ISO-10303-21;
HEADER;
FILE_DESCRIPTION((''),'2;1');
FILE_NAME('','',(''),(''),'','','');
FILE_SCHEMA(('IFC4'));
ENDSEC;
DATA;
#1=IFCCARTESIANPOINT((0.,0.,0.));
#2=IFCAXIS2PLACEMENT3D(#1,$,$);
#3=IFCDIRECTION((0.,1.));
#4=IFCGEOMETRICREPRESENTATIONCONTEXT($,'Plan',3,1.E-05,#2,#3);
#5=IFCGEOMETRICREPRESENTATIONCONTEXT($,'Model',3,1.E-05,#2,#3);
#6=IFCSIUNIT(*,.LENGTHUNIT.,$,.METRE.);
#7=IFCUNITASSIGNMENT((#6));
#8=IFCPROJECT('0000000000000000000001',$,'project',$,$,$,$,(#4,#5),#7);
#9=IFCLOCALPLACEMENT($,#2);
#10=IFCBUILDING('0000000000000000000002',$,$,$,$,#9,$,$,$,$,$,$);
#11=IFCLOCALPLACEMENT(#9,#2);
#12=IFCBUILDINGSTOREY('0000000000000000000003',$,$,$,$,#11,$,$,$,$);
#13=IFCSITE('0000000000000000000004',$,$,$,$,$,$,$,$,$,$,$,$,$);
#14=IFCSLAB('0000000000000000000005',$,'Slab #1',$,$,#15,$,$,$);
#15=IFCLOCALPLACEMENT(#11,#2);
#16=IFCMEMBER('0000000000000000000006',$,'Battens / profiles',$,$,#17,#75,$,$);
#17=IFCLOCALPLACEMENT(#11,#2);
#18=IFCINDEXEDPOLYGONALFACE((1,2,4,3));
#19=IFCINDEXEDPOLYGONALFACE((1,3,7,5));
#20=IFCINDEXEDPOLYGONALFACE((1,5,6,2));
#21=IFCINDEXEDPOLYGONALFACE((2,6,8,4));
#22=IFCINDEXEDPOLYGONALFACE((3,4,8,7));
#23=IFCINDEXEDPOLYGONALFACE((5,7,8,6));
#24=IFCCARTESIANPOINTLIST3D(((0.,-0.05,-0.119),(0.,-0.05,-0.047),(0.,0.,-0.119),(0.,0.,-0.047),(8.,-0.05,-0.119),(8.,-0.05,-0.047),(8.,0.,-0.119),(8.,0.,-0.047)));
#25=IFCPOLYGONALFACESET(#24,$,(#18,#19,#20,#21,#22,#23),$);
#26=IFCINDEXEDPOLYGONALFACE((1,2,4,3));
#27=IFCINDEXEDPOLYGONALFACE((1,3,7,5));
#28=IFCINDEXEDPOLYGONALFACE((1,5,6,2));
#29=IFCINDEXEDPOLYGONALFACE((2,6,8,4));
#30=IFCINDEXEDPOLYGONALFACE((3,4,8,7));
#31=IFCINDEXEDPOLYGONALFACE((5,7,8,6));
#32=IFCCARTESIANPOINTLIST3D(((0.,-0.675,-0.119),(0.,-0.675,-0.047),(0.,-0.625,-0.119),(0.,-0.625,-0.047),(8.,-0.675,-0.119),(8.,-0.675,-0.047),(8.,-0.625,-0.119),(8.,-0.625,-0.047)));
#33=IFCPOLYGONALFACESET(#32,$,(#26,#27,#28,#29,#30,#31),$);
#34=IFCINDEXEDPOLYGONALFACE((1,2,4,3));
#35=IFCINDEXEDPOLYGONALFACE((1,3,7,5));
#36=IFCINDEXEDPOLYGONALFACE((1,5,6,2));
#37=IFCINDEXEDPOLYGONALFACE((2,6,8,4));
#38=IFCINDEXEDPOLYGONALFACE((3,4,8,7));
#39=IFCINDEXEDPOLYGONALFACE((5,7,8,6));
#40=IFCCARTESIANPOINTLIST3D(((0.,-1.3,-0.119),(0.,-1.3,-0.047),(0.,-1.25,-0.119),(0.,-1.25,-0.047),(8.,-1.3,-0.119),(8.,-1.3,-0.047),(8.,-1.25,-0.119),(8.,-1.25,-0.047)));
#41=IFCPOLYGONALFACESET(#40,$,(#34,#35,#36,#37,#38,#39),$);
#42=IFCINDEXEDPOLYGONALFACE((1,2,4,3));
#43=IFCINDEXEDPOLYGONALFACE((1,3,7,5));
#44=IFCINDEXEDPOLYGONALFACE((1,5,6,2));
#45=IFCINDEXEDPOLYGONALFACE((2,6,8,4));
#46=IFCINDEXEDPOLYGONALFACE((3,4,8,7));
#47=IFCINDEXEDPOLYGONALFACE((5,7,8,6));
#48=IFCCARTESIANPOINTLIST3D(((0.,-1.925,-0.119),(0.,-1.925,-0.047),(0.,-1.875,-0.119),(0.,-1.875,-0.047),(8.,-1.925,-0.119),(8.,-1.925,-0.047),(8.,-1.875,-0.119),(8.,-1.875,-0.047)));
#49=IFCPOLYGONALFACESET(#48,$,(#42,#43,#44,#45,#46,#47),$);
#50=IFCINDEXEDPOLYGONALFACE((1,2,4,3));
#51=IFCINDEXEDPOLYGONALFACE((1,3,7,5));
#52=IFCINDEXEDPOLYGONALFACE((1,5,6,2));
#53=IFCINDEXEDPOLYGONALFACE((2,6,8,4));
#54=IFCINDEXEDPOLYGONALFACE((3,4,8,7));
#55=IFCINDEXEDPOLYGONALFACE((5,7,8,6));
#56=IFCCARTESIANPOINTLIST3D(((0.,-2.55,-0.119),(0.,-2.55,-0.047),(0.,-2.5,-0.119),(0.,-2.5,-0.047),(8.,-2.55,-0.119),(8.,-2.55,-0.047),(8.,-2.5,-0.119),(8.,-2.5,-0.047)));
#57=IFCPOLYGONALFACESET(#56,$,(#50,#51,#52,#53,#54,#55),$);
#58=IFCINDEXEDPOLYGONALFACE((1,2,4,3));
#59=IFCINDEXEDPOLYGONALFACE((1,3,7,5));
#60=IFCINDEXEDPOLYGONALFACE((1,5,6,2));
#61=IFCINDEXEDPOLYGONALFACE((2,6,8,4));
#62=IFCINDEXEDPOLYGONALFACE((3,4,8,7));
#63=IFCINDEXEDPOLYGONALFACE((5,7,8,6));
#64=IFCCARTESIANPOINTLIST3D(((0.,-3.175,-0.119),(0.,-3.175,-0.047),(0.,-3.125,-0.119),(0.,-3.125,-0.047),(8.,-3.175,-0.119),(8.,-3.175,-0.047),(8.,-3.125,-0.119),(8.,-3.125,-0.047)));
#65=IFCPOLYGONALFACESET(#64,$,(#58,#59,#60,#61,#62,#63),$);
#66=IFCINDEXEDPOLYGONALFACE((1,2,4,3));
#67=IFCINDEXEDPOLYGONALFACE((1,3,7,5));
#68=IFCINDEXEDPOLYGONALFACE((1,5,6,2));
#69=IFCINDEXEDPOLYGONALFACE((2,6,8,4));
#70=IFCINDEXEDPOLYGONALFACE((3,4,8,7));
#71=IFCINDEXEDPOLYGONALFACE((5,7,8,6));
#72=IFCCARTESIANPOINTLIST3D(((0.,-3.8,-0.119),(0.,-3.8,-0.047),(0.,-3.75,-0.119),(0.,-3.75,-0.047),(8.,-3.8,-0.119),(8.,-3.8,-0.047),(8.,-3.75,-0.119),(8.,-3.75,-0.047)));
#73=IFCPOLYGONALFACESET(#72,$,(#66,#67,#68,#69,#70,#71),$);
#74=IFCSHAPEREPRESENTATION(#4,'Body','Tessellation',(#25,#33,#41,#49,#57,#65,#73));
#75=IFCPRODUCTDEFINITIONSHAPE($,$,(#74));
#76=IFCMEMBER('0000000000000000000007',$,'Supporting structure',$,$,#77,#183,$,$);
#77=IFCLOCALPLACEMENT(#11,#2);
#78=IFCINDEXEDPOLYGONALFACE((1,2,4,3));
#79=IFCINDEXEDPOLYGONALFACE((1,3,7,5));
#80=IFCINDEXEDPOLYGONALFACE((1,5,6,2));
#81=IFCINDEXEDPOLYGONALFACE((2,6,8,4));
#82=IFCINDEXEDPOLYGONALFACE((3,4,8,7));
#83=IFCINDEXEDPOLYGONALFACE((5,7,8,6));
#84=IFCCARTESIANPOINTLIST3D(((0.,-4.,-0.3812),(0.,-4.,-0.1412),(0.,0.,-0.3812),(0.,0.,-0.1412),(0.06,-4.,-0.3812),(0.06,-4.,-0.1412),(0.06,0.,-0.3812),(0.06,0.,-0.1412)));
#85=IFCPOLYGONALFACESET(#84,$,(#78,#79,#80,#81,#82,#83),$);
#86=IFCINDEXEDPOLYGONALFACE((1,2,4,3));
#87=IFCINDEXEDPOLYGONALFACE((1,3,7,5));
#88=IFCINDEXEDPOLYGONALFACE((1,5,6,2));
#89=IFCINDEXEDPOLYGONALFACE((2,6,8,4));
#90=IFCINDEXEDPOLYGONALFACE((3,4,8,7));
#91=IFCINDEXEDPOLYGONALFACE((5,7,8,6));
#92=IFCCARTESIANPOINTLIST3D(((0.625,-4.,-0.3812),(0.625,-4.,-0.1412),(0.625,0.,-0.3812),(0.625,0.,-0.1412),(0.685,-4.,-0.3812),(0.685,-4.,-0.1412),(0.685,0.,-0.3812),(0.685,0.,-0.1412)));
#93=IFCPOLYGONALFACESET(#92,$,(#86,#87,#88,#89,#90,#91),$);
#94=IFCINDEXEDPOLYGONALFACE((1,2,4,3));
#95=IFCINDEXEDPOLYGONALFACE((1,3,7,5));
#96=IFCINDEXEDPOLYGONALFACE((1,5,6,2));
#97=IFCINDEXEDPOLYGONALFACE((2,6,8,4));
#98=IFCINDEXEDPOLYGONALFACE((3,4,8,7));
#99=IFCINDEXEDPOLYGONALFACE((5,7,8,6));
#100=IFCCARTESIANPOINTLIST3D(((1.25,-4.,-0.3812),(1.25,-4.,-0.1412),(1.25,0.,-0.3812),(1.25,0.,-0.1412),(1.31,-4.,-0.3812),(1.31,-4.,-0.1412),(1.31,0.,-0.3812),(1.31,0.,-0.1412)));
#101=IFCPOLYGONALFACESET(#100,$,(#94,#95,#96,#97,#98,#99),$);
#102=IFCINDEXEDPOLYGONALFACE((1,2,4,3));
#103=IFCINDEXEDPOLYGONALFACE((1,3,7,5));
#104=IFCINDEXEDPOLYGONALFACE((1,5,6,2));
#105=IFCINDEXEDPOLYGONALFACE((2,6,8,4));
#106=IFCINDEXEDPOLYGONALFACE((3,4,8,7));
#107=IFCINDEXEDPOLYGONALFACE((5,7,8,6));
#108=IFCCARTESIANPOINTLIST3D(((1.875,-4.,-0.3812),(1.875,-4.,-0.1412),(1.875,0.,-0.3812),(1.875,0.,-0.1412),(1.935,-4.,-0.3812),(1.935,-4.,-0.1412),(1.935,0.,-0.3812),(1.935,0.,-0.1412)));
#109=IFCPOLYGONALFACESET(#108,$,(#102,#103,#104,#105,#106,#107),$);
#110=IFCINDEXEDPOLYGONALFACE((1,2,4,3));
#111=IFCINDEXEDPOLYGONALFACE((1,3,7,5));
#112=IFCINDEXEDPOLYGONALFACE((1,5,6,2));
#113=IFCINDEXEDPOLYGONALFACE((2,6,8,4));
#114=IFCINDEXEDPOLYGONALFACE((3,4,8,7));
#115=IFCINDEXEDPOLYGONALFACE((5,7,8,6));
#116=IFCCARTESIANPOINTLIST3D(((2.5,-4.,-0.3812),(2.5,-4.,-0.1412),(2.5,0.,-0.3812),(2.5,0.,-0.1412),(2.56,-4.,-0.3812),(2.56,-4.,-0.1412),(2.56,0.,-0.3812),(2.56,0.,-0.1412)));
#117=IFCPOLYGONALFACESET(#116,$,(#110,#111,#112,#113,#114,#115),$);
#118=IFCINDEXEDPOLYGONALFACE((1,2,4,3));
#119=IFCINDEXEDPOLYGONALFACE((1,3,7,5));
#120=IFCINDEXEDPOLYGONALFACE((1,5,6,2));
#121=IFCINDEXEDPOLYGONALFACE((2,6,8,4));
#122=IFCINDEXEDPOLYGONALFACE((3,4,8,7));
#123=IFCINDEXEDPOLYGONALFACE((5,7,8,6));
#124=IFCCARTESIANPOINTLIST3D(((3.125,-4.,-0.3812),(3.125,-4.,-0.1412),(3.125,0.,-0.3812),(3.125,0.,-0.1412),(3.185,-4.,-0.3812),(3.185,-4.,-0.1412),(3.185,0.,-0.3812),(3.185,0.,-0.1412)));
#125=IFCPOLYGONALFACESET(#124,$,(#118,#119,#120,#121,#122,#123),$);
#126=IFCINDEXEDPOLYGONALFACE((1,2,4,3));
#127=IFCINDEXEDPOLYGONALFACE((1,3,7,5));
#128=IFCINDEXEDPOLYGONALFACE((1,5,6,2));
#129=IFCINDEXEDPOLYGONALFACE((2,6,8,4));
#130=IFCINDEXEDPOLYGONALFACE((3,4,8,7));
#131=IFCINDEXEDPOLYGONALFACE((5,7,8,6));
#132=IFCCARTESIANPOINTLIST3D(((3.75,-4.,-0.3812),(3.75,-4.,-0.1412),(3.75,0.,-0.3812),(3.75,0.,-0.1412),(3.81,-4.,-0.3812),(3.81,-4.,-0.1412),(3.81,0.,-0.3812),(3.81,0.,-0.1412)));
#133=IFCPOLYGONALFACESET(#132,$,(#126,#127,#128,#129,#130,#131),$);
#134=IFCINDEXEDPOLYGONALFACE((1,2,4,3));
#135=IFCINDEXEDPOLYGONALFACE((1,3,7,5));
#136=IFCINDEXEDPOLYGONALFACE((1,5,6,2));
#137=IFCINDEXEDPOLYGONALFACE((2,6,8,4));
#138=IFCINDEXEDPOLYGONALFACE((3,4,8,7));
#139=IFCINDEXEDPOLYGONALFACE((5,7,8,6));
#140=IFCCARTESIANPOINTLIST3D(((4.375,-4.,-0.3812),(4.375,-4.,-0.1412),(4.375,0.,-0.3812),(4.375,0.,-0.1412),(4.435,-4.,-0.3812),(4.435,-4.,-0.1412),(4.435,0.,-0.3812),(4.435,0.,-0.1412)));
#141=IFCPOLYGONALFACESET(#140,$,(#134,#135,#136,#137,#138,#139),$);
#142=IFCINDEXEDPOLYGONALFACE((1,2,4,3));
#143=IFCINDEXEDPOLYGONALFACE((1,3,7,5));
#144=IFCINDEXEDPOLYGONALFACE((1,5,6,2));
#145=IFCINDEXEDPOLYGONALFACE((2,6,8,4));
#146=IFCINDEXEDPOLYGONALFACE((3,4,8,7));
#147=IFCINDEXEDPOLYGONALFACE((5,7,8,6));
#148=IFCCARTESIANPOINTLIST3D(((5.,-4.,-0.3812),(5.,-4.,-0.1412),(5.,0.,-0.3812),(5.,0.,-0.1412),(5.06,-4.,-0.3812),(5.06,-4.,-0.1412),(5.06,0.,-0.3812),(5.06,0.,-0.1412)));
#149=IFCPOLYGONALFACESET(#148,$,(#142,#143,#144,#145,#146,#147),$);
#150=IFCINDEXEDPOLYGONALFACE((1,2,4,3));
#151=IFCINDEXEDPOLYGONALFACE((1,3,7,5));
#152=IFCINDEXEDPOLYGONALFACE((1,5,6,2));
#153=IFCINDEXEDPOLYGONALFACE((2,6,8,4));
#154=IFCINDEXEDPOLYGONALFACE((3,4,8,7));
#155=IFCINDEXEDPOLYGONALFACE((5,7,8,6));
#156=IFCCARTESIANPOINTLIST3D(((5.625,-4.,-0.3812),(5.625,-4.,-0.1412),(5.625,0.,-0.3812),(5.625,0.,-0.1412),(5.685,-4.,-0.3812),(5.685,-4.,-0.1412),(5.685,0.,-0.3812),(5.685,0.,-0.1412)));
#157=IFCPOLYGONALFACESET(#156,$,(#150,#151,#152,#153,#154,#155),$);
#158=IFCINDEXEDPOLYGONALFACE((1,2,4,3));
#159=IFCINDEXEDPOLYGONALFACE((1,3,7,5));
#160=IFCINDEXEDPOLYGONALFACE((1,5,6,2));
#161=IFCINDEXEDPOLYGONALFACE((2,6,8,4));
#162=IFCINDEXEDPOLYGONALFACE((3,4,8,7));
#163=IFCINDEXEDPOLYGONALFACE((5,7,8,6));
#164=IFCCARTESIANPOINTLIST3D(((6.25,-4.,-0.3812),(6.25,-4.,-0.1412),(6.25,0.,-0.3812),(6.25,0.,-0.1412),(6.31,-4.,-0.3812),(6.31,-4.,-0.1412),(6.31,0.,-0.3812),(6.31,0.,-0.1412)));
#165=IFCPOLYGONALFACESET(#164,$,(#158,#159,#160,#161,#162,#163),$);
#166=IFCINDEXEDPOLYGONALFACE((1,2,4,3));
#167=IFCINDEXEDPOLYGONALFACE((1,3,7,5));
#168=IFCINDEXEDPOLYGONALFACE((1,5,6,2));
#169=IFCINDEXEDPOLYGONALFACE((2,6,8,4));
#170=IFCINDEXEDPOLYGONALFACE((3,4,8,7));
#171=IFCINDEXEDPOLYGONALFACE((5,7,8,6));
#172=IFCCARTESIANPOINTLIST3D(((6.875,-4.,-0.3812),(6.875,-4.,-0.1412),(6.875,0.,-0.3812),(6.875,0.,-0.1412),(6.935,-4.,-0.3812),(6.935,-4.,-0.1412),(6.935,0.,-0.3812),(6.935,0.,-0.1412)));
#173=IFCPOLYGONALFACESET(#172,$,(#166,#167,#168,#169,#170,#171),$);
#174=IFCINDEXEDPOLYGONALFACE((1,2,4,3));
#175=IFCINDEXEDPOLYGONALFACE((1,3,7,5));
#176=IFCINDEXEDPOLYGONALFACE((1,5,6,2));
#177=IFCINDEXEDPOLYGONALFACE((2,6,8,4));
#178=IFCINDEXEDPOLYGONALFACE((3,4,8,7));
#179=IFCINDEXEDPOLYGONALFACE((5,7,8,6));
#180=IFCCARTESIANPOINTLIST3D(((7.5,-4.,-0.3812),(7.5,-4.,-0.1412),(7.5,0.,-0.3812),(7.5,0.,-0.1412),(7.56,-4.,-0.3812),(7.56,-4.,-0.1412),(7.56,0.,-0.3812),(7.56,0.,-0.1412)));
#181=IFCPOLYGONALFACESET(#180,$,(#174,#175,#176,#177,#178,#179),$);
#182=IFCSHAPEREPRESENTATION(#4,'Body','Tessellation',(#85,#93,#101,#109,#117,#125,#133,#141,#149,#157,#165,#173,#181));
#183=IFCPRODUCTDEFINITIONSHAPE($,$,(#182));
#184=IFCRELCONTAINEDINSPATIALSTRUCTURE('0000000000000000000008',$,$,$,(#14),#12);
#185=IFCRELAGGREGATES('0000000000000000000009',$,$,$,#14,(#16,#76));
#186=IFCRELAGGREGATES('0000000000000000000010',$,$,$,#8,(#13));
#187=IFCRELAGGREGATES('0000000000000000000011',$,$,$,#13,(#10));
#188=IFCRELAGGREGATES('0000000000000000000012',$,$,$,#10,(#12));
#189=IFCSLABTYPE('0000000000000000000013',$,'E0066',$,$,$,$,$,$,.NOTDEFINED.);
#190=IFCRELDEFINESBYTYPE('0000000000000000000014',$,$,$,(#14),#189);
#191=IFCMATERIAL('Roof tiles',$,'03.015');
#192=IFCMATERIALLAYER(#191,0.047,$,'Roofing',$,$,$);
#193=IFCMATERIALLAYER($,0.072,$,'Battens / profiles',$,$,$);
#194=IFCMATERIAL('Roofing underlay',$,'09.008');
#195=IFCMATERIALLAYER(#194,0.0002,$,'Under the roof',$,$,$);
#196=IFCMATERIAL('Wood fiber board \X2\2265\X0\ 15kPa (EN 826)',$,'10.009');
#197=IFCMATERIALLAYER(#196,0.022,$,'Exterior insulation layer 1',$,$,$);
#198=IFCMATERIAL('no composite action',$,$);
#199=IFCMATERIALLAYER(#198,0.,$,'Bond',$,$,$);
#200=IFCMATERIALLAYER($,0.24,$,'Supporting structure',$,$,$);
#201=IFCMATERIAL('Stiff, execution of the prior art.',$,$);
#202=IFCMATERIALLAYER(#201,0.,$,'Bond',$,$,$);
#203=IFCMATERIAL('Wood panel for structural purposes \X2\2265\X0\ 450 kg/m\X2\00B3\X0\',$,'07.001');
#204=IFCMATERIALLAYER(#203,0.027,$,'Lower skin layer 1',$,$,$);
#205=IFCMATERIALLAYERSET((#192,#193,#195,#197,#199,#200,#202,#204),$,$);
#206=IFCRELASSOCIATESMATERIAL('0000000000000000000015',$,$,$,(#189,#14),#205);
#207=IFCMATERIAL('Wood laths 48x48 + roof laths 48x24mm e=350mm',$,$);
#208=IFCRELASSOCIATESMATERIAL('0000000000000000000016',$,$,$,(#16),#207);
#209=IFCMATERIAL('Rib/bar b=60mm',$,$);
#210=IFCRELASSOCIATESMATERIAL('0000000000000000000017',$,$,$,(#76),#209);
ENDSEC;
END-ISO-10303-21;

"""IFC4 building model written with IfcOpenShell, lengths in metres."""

from ifc_helpers import new_model, si_unit, direction, frame, frame_2d, origin, place, context, project, spatial, rectangle, extrude, material, layer, layer_set, type_object, element, aggregate, save


model = new_model("IFC4")

# Units and contexts
plan_context = context("Plan", 3, precision=1e-05, world=origin(), true_north=direction((0.0, 1.0)))
model_context = context("Model", 3, precision=1e-05, world=origin(), true_north=direction((0.0, 1.0)))
ifc_project = project(units=[si_unit("LENGTHUNIT", "METRE")], contexts=[plan_context, model_context])

# Site, building, storey
site = spatial("IfcSite", under=ifc_project)
building_placement = place(None, origin())
building = spatial("IfcBuilding", under=site, at=building_placement)
storey_placement = place(building_placement, origin())
storey = spatial("IfcBuildingStorey", under=building, at=storey_placement)

# Slab, members
ifc_material_1 = material(Name="Roof tiles", Category="03.015")
ifc_layer_1 = layer(ifc_material_1, 0.047, Name="Roofing")
ifc_layer_2 = layer(None, 0.072, Name="Battens / profiles")
ifc_material_2 = material(Name="Roofing underlay", Category="09.008")
ifc_layer_3 = layer(ifc_material_2, 0.0002, Name="Under the roof")
ifc_material_3 = material(Name="Wood fiber board ≥ 15kPa (EN 826)", Category="10.009")
ifc_layer_4 = layer(ifc_material_3, 0.022, Name="Exterior insulation layer 1")
ifc_material_4 = material(Name="no composite action")
ifc_layer_5 = layer(ifc_material_4, 0.0, Name="Bond")
ifc_layer_6 = layer(None, 0.24, Name="Supporting structure")
ifc_material_5 = material(Name="Stiff, execution of the prior art.")
ifc_layer_7 = layer(ifc_material_5, 0.0, Name="Bond")
ifc_material_6 = material(Name="Wood panel for structural purposes ≥ 450 kg/m³", Category="07.001")
ifc_layer_8 = layer(ifc_material_6, 0.027, Name="Lower skin layer 1")
ifc_layer_set = layer_set([ifc_layer_1, ifc_layer_2, ifc_layer_3, ifc_layer_4, ifc_layer_5, ifc_layer_6, ifc_layer_7, ifc_layer_8])
slab_type = type_object("IfcSlabType", Name="E0066", PredefinedType="NOTDEFINED", material=ifc_layer_set)
slab_placement = place(None, frame((0.0, 0.0, 0.0), z_axis=(0.0, 0.0, -1.0), x_axis=(1.0, 0.0, 0.0)))
slab = element("IfcSlab", 1, at=slab_placement, inside=storey, type_object=slab_type, material=ifc_layer_set, Name="Slab #1")
ifc_material_7 = material(Name="Wood laths 48x48 + roof laths 48x24mm e=350mm")
member_1_placement = place(slab_placement, origin())
member_1 = element("IfcMember", 2, at=member_1_placement, material=ifc_material_7, Name="Battens / profiles", context=plan_context, shape_type="SweptSolid", body=[
    extrude(rectangle(XDim=0.05, YDim=0.072, at=frame_2d((0.025, 0.036), x_axis=(1.0, 0.0))), frame((0.0, 0.0, 0.047), z_axis=(1.0, 0.0, 0.0), x_axis=(0.0, 1.0, 0.0)), (0.0, 0.0, 1.0), 8.0),
    extrude(rectangle(XDim=0.05, YDim=0.072, at=frame_2d((0.025, 0.036), x_axis=(1.0, 0.0))), frame((0.0, 0.625, 0.047), z_axis=(1.0, 0.0, 0.0), x_axis=(0.0, 1.0, 0.0)), (0.0, 0.0, 1.0), 8.0),
    extrude(rectangle(XDim=0.05, YDim=0.072, at=frame_2d((0.025, 0.036), x_axis=(1.0, 0.0))), frame((0.0, 1.25, 0.047), z_axis=(1.0, 0.0, 0.0), x_axis=(0.0, 1.0, 0.0)), (0.0, 0.0, 1.0), 8.0),
    extrude(rectangle(XDim=0.05, YDim=0.072, at=frame_2d((0.025, 0.036), x_axis=(1.0, 0.0))), frame((0.0, 1.875, 0.047), z_axis=(1.0, 0.0, 0.0), x_axis=(0.0, 1.0, 0.0)), (0.0, 0.0, 1.0), 8.0),
    extrude(rectangle(XDim=0.05, YDim=0.072, at=frame_2d((0.025, 0.036), x_axis=(1.0, 0.0))), frame((0.0, 2.5, 0.047), z_axis=(1.0, 0.0, 0.0), x_axis=(0.0, 1.0, 0.0)), (0.0, 0.0, 1.0), 8.0),
    extrude(rectangle(XDim=0.05, YDim=0.072, at=frame_2d((0.025, 0.036), x_axis=(1.0, 0.0))), frame((0.0, 3.125, 0.047), z_axis=(1.0, 0.0, 0.0), x_axis=(0.0, 1.0, 0.0)), (0.0, 0.0, 1.0), 8.0),
    extrude(rectangle(XDim=0.05, YDim=0.072, at=frame_2d((0.025, 0.036), x_axis=(1.0, 0.0))), frame((0.0, 3.75, 0.047), z_axis=(1.0, 0.0, 0.0), x_axis=(0.0, 1.0, 0.0)), (0.0, 0.0, 1.0), 8.0),
])
ifc_material_8 = material(Name="Rib/bar b=60mm")
member_2_placement = place(slab_placement, origin())
member_2 = element("IfcMember", 3, at=member_2_placement, material=ifc_material_8, Name="Supporting structure", context=plan_context, shape_type="SweptSolid", body=[
    extrude(rectangle(XDim=0.06, YDim=0.24, at=frame_2d((0.03, 0.12), x_axis=(1.0, 0.0))), frame((0.0, 4.0, 0.1412), z_axis=(0.0, -1.0, 0.0), x_axis=(1.0, 0.0, 0.0)), (0.0, 0.0, 1.0), 4.0),
    extrude(rectangle(XDim=0.06, YDim=0.24, at=frame_2d((0.03, 0.12), x_axis=(1.0, 0.0))), frame((0.625, 4.0, 0.1412), z_axis=(0.0, -1.0, 0.0), x_axis=(1.0, 0.0, 0.0)), (0.0, 0.0, 1.0), 4.0),
    extrude(rectangle(XDim=0.06, YDim=0.24, at=frame_2d((0.03, 0.12), x_axis=(1.0, 0.0))), frame((1.25, 4.0, 0.1412), z_axis=(0.0, -1.0, 0.0), x_axis=(1.0, 0.0, 0.0)), (0.0, 0.0, 1.0), 4.0),
    extrude(rectangle(XDim=0.06, YDim=0.24, at=frame_2d((0.03, 0.12), x_axis=(1.0, 0.0))), frame((1.875, 4.0, 0.1412), z_axis=(0.0, -1.0, 0.0), x_axis=(1.0, 0.0, 0.0)), (0.0, 0.0, 1.0), 4.0),
    extrude(rectangle(XDim=0.06, YDim=0.24, at=frame_2d((0.03, 0.12), x_axis=(1.0, 0.0))), frame((2.5, 4.0, 0.1412), z_axis=(0.0, -1.0, 0.0), x_axis=(1.0, 0.0, 0.0)), (0.0, 0.0, 1.0), 4.0),
    extrude(rectangle(XDim=0.06, YDim=0.24, at=frame_2d((0.03, 0.12), x_axis=(1.0, 0.0))), frame((3.125, 4.0, 0.1412), z_axis=(0.0, -1.0, 0.0), x_axis=(1.0, 0.0, 0.0)), (0.0, 0.0, 1.0), 4.0),
    extrude(rectangle(XDim=0.06, YDim=0.24, at=frame_2d((0.03, 0.12), x_axis=(1.0, 0.0))), frame((3.75, 4.0, 0.1412), z_axis=(0.0, -1.0, 0.0), x_axis=(1.0, 0.0, 0.0)), (0.0, 0.0, 1.0), 4.0),
    extrude(rectangle(XDim=0.06, YDim=0.24, at=frame_2d((0.03, 0.12), x_axis=(1.0, 0.0))), frame((4.375, 4.0, 0.1412), z_axis=(0.0, -1.0, 0.0), x_axis=(1.0, 0.0, 0.0)), (0.0, 0.0, 1.0), 4.0),
    extrude(rectangle(XDim=0.06, YDim=0.24, at=frame_2d((0.03, 0.12), x_axis=(1.0, 0.0))), frame((5.0, 4.0, 0.1412), z_axis=(0.0, -1.0, 0.0), x_axis=(1.0, 0.0, 0.0)), (0.0, 0.0, 1.0), 4.0),
    extrude(rectangle(XDim=0.06, YDim=0.24, at=frame_2d((0.03, 0.12), x_axis=(1.0, 0.0))), frame((5.625, 4.0, 0.1412), z_axis=(0.0, -1.0, 0.0), x_axis=(1.0, 0.0, 0.0)), (0.0, 0.0, 1.0), 4.0),
    extrude(rectangle(XDim=0.06, YDim=0.24, at=frame_2d((0.03, 0.12), x_axis=(1.0, 0.0))), frame((6.25, 4.0, 0.1412), z_axis=(0.0, -1.0, 0.0), x_axis=(1.0, 0.0, 0.0)), (0.0, 0.0, 1.0), 4.0),
    extrude(rectangle(XDim=0.06, YDim=0.24, at=frame_2d((0.03, 0.12), x_axis=(1.0, 0.0))), frame((6.875, 4.0, 0.1412), z_axis=(0.0, -1.0, 0.0), x_axis=(1.0, 0.0, 0.0)), (0.0, 0.0, 1.0), 4.0),
    extrude(rectangle(XDim=0.06, YDim=0.24, at=frame_2d((0.03, 0.12), x_axis=(1.0, 0.0))), frame((7.5, 4.0, 0.1412), z_axis=(0.0, -1.0, 0.0), x_axis=(1.0, 0.0, 0.0)), (0.0, 0.0, 1.0), 4.0),
])
aggregate(slab, [member_1, member_2])

save(model, "model.ifc")
